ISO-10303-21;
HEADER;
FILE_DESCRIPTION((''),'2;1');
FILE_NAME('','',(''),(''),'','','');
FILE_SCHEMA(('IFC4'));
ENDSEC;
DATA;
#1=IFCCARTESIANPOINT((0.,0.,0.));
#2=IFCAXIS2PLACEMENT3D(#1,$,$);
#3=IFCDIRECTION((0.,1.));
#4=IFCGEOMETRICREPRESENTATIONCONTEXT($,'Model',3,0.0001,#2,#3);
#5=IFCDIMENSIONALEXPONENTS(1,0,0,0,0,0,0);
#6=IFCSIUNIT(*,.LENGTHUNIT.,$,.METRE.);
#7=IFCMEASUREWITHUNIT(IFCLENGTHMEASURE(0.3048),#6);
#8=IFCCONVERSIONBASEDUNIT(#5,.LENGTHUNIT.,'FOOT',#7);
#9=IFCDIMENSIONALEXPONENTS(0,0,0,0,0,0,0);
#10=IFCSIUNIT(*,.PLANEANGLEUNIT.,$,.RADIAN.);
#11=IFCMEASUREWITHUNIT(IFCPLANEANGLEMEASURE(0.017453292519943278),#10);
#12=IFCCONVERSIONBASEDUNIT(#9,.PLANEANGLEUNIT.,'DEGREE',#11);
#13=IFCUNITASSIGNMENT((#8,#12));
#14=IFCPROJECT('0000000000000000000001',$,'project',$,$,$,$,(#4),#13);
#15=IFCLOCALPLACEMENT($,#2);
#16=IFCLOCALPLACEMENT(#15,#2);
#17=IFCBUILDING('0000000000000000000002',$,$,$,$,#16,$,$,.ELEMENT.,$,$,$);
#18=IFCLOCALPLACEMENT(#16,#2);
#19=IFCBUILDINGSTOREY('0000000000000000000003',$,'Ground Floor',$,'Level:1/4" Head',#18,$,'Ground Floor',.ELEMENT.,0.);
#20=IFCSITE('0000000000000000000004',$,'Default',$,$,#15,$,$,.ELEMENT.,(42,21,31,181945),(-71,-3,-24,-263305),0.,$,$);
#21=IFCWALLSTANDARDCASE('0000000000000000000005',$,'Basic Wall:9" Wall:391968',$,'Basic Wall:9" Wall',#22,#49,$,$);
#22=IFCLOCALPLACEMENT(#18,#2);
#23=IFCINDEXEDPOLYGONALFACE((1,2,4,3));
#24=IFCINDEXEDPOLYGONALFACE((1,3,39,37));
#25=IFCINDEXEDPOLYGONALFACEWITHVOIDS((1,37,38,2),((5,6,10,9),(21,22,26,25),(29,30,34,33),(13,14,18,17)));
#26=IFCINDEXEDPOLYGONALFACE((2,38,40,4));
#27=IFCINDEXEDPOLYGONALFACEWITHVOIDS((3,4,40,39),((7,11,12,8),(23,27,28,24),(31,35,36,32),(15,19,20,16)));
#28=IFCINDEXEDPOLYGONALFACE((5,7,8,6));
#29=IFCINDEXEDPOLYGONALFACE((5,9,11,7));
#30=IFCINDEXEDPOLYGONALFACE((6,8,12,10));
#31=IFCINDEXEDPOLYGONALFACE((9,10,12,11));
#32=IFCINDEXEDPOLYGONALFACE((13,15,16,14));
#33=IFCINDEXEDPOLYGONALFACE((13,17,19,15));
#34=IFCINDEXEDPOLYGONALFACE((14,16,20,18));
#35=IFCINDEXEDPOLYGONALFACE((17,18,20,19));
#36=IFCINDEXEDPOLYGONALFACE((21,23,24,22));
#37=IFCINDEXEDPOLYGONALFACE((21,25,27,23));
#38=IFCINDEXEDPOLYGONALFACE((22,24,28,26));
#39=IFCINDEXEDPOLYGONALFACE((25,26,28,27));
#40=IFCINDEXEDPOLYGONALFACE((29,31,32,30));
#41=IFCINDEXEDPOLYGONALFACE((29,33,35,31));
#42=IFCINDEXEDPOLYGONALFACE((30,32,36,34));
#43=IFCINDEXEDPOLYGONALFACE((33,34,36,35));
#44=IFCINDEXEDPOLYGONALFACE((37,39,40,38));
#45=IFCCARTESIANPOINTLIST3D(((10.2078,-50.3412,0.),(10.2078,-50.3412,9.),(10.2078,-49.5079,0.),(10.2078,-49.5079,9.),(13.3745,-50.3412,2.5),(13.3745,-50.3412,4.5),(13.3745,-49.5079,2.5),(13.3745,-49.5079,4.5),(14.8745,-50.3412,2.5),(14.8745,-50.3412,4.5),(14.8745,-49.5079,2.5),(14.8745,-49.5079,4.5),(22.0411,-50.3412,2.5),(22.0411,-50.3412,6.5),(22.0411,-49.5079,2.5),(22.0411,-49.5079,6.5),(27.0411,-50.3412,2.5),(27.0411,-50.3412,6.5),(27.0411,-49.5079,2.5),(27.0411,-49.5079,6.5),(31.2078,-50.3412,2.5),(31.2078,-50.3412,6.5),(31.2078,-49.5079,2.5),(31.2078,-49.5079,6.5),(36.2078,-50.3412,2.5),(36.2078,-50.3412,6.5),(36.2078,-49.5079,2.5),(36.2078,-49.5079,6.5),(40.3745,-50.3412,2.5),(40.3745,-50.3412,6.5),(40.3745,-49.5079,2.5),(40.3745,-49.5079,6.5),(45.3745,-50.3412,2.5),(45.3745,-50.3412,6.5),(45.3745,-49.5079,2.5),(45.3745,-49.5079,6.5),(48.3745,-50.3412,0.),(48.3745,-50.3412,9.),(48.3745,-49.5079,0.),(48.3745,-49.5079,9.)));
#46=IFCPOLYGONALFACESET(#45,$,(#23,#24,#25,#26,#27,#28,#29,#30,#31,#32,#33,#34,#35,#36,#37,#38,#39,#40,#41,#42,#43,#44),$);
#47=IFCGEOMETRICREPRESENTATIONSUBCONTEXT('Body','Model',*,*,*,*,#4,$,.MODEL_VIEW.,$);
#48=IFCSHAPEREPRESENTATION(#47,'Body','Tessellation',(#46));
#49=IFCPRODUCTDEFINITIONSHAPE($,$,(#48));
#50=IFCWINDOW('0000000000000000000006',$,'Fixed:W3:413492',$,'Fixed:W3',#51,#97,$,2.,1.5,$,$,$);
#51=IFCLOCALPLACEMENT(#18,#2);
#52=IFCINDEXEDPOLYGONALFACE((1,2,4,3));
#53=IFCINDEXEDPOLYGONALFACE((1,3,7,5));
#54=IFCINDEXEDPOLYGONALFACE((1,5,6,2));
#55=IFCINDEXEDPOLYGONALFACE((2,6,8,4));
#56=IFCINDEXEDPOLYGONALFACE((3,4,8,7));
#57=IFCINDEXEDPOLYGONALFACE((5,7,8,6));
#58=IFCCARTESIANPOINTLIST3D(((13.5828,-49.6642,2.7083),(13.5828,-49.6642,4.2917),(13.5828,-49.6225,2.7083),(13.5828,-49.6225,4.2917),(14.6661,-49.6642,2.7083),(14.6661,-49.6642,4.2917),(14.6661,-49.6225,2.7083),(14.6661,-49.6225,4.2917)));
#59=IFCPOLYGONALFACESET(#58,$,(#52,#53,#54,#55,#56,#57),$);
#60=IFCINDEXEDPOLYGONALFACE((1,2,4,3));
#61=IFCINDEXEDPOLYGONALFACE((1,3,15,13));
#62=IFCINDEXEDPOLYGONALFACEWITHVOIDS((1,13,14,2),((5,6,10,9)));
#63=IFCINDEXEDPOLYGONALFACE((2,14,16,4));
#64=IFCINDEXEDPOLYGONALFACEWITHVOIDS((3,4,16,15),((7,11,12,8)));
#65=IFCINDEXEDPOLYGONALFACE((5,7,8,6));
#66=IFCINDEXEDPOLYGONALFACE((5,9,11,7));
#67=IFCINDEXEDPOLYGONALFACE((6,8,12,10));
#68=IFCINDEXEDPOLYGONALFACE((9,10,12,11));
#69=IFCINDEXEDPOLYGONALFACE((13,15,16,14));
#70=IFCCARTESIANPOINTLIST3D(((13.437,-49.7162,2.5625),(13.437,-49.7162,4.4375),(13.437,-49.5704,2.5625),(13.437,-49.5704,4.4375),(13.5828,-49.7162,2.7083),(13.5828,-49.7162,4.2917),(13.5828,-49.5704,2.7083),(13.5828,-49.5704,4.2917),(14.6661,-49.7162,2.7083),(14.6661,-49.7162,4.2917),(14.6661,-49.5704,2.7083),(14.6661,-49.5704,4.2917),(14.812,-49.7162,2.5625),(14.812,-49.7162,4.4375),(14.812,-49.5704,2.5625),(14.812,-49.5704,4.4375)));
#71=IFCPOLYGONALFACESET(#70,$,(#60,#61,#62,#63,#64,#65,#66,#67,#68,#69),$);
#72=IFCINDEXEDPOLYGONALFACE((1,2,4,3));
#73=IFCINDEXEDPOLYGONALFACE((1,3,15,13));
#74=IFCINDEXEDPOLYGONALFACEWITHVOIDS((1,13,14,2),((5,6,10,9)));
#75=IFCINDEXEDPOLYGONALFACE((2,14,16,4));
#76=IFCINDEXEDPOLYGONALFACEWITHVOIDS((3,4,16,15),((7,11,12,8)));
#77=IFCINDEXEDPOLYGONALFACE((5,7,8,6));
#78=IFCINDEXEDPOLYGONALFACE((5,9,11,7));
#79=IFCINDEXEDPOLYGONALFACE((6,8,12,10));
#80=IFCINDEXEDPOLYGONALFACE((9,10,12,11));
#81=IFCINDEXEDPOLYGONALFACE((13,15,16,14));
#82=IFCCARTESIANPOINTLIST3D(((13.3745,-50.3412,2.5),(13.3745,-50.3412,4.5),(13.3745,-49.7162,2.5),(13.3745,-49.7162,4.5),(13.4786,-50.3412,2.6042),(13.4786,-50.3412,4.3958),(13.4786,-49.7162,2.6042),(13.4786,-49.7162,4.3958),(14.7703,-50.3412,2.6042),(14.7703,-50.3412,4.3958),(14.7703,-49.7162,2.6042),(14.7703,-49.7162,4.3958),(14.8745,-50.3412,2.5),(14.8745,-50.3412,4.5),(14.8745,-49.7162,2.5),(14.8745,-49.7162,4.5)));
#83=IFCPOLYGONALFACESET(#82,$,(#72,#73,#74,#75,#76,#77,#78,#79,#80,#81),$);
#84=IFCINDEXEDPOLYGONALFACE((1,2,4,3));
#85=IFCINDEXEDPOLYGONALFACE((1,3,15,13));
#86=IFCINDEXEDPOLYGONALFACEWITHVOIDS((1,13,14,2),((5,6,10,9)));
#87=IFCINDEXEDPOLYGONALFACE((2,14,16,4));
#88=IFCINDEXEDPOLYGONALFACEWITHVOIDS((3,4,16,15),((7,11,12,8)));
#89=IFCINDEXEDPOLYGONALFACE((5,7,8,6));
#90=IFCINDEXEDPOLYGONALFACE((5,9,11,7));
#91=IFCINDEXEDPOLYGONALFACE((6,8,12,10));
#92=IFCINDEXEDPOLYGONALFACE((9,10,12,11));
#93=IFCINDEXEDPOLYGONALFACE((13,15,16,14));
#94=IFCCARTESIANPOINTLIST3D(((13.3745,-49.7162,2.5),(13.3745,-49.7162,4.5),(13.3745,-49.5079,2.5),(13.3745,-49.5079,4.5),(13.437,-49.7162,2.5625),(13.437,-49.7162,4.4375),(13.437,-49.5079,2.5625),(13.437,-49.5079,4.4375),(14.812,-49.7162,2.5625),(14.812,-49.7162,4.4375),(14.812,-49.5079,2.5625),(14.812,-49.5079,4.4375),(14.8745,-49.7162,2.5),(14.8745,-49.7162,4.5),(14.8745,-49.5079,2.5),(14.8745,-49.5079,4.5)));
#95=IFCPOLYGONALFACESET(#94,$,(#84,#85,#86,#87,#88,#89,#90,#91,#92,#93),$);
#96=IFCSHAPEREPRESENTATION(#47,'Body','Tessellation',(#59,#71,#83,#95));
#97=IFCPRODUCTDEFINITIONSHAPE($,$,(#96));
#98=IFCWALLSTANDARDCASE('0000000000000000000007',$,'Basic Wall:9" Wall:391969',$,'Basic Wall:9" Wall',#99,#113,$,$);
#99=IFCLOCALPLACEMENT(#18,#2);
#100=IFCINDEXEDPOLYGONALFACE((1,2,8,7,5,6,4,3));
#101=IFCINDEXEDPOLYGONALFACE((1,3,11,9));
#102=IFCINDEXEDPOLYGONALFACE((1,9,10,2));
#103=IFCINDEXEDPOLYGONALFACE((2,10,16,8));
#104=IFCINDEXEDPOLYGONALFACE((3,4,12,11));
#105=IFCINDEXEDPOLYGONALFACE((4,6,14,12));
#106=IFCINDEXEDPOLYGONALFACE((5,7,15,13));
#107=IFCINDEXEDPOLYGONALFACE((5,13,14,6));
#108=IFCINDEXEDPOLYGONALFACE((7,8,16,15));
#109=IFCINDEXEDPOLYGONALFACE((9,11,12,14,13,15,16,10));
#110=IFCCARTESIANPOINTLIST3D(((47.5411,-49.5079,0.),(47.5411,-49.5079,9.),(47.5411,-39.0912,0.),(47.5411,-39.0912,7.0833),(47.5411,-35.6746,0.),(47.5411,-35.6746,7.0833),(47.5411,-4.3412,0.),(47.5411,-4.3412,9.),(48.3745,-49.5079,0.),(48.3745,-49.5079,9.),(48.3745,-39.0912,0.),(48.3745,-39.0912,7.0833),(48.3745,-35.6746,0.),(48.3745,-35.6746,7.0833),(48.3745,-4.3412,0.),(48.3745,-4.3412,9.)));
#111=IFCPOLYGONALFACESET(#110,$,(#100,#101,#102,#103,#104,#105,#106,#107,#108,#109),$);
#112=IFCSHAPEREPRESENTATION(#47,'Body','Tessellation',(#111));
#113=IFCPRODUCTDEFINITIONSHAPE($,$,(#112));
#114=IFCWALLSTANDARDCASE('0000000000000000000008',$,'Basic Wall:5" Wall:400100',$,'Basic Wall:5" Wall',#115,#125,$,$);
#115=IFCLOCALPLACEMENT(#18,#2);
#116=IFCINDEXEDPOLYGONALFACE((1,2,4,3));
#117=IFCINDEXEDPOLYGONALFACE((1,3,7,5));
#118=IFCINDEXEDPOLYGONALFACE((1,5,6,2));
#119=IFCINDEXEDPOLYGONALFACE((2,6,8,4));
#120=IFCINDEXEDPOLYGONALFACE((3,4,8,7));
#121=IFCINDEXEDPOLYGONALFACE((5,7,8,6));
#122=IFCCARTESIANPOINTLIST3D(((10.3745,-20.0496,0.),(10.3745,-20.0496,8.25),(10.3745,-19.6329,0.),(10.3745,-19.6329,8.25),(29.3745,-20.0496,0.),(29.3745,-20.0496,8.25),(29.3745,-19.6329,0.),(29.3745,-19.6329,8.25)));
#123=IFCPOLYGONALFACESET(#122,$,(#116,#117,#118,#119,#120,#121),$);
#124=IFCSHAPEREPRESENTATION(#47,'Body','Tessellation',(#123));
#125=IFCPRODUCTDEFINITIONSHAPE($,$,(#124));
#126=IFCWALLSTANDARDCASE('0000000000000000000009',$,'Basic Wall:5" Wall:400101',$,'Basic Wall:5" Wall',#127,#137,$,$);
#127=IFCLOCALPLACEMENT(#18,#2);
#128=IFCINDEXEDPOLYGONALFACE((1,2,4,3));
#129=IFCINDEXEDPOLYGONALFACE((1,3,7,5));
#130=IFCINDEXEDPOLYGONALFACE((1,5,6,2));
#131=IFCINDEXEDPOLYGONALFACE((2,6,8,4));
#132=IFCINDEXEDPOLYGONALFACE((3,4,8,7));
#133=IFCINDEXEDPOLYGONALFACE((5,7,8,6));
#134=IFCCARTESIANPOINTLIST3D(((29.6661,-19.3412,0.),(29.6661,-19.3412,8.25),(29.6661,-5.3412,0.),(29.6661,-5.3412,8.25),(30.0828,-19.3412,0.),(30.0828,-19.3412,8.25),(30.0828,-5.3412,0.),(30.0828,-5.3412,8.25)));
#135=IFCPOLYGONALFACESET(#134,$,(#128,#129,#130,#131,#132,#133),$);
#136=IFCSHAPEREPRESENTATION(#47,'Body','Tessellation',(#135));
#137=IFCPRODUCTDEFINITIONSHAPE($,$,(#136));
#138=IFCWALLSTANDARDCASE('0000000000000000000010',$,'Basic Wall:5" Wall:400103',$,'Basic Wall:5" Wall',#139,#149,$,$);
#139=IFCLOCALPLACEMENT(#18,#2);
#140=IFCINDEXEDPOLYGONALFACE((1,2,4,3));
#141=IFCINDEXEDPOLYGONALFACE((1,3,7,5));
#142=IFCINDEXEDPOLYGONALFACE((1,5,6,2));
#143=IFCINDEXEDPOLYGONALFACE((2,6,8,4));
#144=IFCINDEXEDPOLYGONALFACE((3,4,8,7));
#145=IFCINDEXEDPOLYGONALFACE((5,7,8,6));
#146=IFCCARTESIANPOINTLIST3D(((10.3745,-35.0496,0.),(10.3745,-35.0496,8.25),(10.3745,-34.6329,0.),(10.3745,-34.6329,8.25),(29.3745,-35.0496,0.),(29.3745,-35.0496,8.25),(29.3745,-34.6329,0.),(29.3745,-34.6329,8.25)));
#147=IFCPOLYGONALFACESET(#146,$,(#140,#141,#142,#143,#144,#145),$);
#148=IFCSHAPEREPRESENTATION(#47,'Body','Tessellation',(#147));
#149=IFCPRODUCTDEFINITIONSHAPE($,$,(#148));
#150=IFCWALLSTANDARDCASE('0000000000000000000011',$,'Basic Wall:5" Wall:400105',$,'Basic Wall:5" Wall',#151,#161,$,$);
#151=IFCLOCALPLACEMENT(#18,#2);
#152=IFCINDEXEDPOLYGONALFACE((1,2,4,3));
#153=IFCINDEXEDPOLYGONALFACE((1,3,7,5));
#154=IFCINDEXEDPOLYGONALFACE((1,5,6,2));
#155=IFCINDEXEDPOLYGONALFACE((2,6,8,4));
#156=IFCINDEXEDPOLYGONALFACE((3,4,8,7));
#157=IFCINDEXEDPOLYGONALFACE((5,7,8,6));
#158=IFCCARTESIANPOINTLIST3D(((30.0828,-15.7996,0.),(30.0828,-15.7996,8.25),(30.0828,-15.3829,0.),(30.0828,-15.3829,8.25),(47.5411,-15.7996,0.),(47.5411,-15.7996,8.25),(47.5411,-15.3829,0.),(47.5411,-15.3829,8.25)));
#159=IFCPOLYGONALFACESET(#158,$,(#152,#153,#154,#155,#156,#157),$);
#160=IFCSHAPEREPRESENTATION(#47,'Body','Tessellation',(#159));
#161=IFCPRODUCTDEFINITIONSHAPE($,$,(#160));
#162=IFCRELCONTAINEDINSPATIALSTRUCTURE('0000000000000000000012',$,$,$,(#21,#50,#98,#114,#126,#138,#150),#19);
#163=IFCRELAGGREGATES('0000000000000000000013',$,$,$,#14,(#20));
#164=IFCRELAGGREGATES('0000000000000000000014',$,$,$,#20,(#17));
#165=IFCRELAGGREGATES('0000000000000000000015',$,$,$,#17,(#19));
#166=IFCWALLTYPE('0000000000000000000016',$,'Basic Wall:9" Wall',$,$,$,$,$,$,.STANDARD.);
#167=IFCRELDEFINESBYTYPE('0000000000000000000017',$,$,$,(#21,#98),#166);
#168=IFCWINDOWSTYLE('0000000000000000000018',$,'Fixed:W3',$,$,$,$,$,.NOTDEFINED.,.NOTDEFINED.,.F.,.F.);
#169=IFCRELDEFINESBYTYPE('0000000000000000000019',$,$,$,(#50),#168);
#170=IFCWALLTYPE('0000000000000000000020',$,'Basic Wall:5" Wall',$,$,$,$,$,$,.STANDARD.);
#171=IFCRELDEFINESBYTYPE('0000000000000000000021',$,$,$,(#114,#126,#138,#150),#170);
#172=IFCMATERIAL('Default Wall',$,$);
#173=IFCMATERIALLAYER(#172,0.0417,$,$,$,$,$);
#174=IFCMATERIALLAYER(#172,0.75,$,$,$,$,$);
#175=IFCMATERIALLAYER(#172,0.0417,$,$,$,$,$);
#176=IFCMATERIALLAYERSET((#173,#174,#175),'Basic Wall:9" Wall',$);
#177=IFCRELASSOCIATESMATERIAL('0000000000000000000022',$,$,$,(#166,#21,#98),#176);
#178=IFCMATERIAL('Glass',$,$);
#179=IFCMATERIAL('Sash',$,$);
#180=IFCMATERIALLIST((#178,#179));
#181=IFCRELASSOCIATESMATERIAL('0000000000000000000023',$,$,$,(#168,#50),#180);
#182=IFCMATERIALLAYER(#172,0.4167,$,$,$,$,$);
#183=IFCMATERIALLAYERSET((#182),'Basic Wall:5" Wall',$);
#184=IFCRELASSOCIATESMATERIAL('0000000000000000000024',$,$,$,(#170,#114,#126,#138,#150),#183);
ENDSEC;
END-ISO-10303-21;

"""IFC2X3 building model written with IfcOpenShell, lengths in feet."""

from ifc_helpers import new_model, entity, si_unit, converted_unit, direction, frame, frame_2d, origin, origin_2d_with_axis, place, context, subcontext, project, spatial, polyline, rectangle, outline, extrude, source, transform, mapped, material, material_list, layer, layer_set, layer_usage, type_object, type_shapes, element, fill, save


model = new_model("IFC2X3")

# Units and contexts
model_context = context("Model", 3, precision=0.0001, world=origin(), true_north=direction((0.0, 1.0)))
body_context = subcontext(model_context, "Body", "Model", "MODEL_VIEW")
ifc_project = project(units=[converted_unit("LENGTHUNIT", "FOOT", entity("IfcLengthMeasure", 0.3048), si_unit("LENGTHUNIT", "METRE"), dimensions=[1, 0, 0, 0, 0, 0, 0]), converted_unit("PLANEANGLEUNIT", "DEGREE", entity("IfcPlaneAngleMeasure", 0.017453292519943278), si_unit("PLANEANGLEUNIT", "RADIAN"), dimensions=[0, 0, 0, 0, 0, 0, 0])], contexts=[model_context])

# Site, building, storey
site_placement = place(None, origin())
site = spatial("IfcSite", under=ifc_project, at=site_placement, Name="Default", CompositionType="ELEMENT", RefLatitude=(42, 21, 31, 181945), RefLongitude=(-71, -3, -24, -263305), RefElevation=0.0)
building_placement = place(site_placement, origin())
building = spatial("IfcBuilding", under=site, at=building_placement, CompositionType="ELEMENT")
storey_placement = place(building_placement, origin())
storey = spatial("IfcBuildingStorey", under=building, at=storey_placement, Name="Ground Floor", ObjectType="Level:1/4\" Head", LongName="Ground Floor", CompositionType="ELEMENT", Elevation=0.0)

# Wall, openings, window
ifc_material_1 = material(Name="Default Wall")
ifc_layer_1 = layer(ifc_material_1, 0.0417)
ifc_layer_2 = layer(ifc_material_1, 0.75)
ifc_layer_3 = layer(ifc_material_1, 0.0417)
ifc_layer_set_1 = layer_set([ifc_layer_1, ifc_layer_2, ifc_layer_3], Name="Basic Wall:9\" Wall")
ifc_layer_usage_1 = layer_usage(ifc_layer_set_1, "AXIS2", "NEGATIVE", 0.4167)
wall_type_1 = type_object("IfcWallType", Name="Basic Wall:9\" Wall", PredefinedType="STANDARD", material=ifc_layer_set_1)
wall_1_placement = place(storey_placement, frame((48.3745, -49.9246, 0.0), z_axis=(0.0, 0.0, 1.0), x_axis=(-1.0, 0.0, 0.0)))
wall_1 = element("IfcWallStandardCase", 1, at=wall_1_placement, inside=storey, type_object=wall_type_1, material=ifc_layer_usage_1, Name="Basic Wall:9\" Wall:391968", ObjectType="Basic Wall:9\" Wall", context=body_context, shape_type="SweptSolid", body=[
    extrude(rectangle(XDim=38.1667, YDim=0.8333, at=frame_2d((19.0833, 0.0), x_axis=(-1.0, 0.0))), origin(), (0.0, 0.0, 1.0), 9.0),
])
opening_1_placement = place(wall_1_placement, frame((3.0, -0.4167, 2.5)))
element("IfcOpeningElement", 2, at=opening_1_placement, cuts=wall_1, ObjectType="Opening", context=body_context, shape_type="SweptSolid", body=[
    extrude(rectangle(XDim=4.0, YDim=5.0, at=frame_2d((2.0, 2.5), x_axis=(-1.0, 0.0))), frame((0.0, 0.0, 0.0), z_axis=(0.0, 1.0, 0.0), x_axis=(0.0, 0.0, 1.0)), (0.0, 0.0, 1.0), 0.8333),
])
opening_2_placement = place(wall_1_placement, frame((12.1667, -0.4167, 2.5)))
element("IfcOpeningElement", 3, at=opening_2_placement, cuts=wall_1, ObjectType="Opening", context=body_context, shape_type="SweptSolid", body=[
    extrude(rectangle(XDim=4.0, YDim=5.0, at=frame_2d((2.0, 2.5), x_axis=(-1.0, 0.0))), frame((0.0, 0.0, 0.0), z_axis=(0.0, 1.0, 0.0), x_axis=(0.0, 0.0, 1.0)), (0.0, 0.0, 1.0), 0.8333),
])
opening_3_placement = place(wall_1_placement, frame((35.0, 0.4167, 2.5)))
opening_3 = element("IfcOpeningElement", 4, at=opening_3_placement, cuts=wall_1, ObjectType="Opening", context=body_context, shape_type="SweptSolid", body=[
    extrude(rectangle(XDim=2.0, YDim=1.5, at=frame_2d((1.0, 0.75), x_axis=(-1.0, 0.0))), frame((0.0, 0.0, 0.0), z_axis=(0.0, -1.0, 0.0), x_axis=(0.0, 0.0, 1.0)), (0.0, 0.0, 1.0), 0.8333),
])
opening_4_placement = place(wall_1_placement, frame((26.3333, 0.4167, 2.5)))
element("IfcOpeningElement", 5, at=opening_4_placement, cuts=wall_1, ObjectType="Opening", context=body_context, shape_type="SweptSolid", body=[
    extrude(rectangle(XDim=4.0, YDim=5.0, at=frame_2d((2.0, 2.5), x_axis=(-1.0, 0.0))), frame((0.0, 0.0, 0.0), z_axis=(0.0, -1.0, 0.0), x_axis=(0.0, 0.0, 1.0)), (0.0, 0.0, 1.0), 0.8333),
])
ifc_material_2 = material(Name="Glass")
ifc_material_3 = material(Name="Sash")
ifc_material_list_1 = material_list([ifc_material_2, ifc_material_3])
window_style = type_object("IfcWindowStyle", Name="Fixed:W3", ConstructionType="NOTDEFINED", OperationType="NOTDEFINED", ParameterTakesPrecedence=False, Sizeable=False, material=ifc_material_list_1)
shared_shape_1 = source(origin(), body_context, "Body", "SweptSolid", [
    extrude(rectangle(XDim=0.0417, YDim=1.0833, at=origin_2d_with_axis()), frame((0.75, 0.6979, 0.2083), z_axis=(0.0, 0.0, 1.0), x_axis=(0.0, 1.0, 0.0)), (0.0, 0.0, 1.0), 1.5833),
    extrude(outline(polyline([(-0.6875, -0.9375), (0.6875, -0.9375), (0.6875, 0.9375), (-0.6875, 0.9375), (-0.6875, -0.9375)]), holes=[polyline([(-0.5417, -0.7917), (-0.5417, 0.7917), (0.5417, 0.7917), (0.5417, -0.7917), (-0.5417, -0.7917)])]), frame((0.75, 0.625, 1.0), z_axis=(0.0, 1.0, 0.0), x_axis=(1.0, 0.0, 0.0)), (0.0, 0.0, 1.0), 0.1458),
    extrude(outline(polyline([(-0.75, -1.0), (0.75, -1.0), (0.75, 1.0), (-0.75, 1.0), (-0.75, -1.0)]), holes=[polyline([(-0.6458, -0.8958), (-0.6458, 0.8958), (0.6458, 0.8958), (0.6458, -0.8958), (-0.6458, -0.8958)])]), frame((0.75, 0.0, 1.0), z_axis=(0.0, 1.0, 0.0), x_axis=(1.0, 0.0, 0.0)), (0.0, 0.0, 1.0), 0.625),
    extrude(outline(polyline([(-1.0, -0.75), (1.0, -0.75), (1.0, 0.75), (-1.0, 0.75), (-1.0, -0.75)]), holes=[polyline([(-0.9375, -0.6875), (-0.9375, 0.6875), (0.9375, 0.6875), (0.9375, -0.6875), (-0.9375, -0.6875)])]), frame((0.75, 0.625, 1.0), z_axis=(0.0, 1.0, 0.0), x_axis=(0.0, 0.0, -1.0)), (0.0, 0.0, 1.0), 0.2083),
])
type_shapes(window_style, [shared_shape_1])
window_placement = place(opening_3_placement, frame((0.0, 0.0, 0.0), z_axis=(0.0, 0.0, 1.0), x_axis=(-1.0, 0.0, 0.0)))
window = element("IfcWindow", 6, at=window_placement, inside=storey, type_object=window_style, material=ifc_material_list_1, Name="Fixed:W3:413492", ObjectType="Fixed:W3", OverallHeight=2.0, OverallWidth=1.5, context=body_context, shape_type="MappedRepresentation", body=[
    mapped(shared_shape_1, transform((0.0, 0.0, 0.0), scale=1.0)),
])
fill(opening_3, window)

# Wall, opening
wall_2_placement = place(storey_placement, frame((47.9578, -4.3412, 0.0), z_axis=(0.0, 0.0, 1.0), x_axis=(0.0, -1.0, 0.0)))
wall_2 = element("IfcWallStandardCase", 7, at=wall_2_placement, inside=storey, type_object=wall_type_1, material=ifc_layer_usage_1, Name="Basic Wall:9\" Wall:391969", ObjectType="Basic Wall:9\" Wall", context=body_context, shape_type="SweptSolid", body=[
    extrude(rectangle(XDim=45.1667, YDim=0.8333, at=frame_2d((22.5833, 0.0), x_axis=(1.0, 0.0))), origin(), (0.0, 0.0, 1.0), 9.0),
])
opening_5_placement = place(wall_2_placement, frame((34.75, 0.4167, 0.0)))
element("IfcOpeningElement", 8, at=opening_5_placement, cuts=wall_2, ObjectType="Opening", context=body_context, shape_type="SweptSolid", body=[
    extrude(rectangle(XDim=7.0833, YDim=3.4167, at=frame_2d((3.5417, 1.7083), x_axis=(1.0, 0.0))), frame((0.0, 0.0, 0.0), z_axis=(0.0, -1.0, 0.0), x_axis=(0.0, 0.0, 1.0)), (0.0, 0.0, 1.0), 0.8333),
])

# Walls
ifc_layer_4 = layer(ifc_material_1, 0.4167)
ifc_layer_set_2 = layer_set([ifc_layer_4], Name="Basic Wall:5\" Wall")
ifc_layer_usage_2 = layer_usage(ifc_layer_set_2, "AXIS2", "NEGATIVE", 0.2083)
wall_type_2 = type_object("IfcWallType", Name="Basic Wall:5\" Wall", PredefinedType="STANDARD", material=ifc_layer_set_2)
wall_3_placement = place(storey_placement, frame((10.3745, -19.8412, 0.0)))
element("IfcWallStandardCase", 9, at=wall_3_placement, inside=storey, type_object=wall_type_2, material=ifc_layer_usage_2, Name="Basic Wall:5\" Wall:400100", ObjectType="Basic Wall:5\" Wall", context=body_context, shape_type="SweptSolid", body=[
    extrude(rectangle(XDim=19.0, YDim=0.4167, at=frame_2d((9.5, 0.0), x_axis=(-1.0, 0.0))), origin(), (0.0, 0.0, 1.0), 8.25),
])
wall_4_placement = place(storey_placement, frame((29.8745, -19.3412, 0.0), z_axis=(0.0, 0.0, 1.0), x_axis=(0.0, 1.0, 0.0)))
element("IfcWallStandardCase", 10, at=wall_4_placement, inside=storey, type_object=wall_type_2, material=ifc_layer_usage_2, Name="Basic Wall:5\" Wall:400101", ObjectType="Basic Wall:5\" Wall", context=body_context, shape_type="SweptSolid", body=[
    extrude(rectangle(XDim=14.0, YDim=0.4167, at=frame_2d((7.0, 0.0), x_axis=(-1.0, 0.0))), origin(), (0.0, 0.0, 1.0), 8.25),
])

# Wall
wall_5_placement = place(storey_placement, frame((29.3745, -34.8412, 0.0), z_axis=(0.0, 0.0, 1.0), x_axis=(-1.0, 0.0, 0.0)))
element("IfcWallStandardCase", 11, at=wall_5_placement, inside=storey, type_object=wall_type_2, material=ifc_layer_usage_2, Name="Basic Wall:5\" Wall:400103", ObjectType="Basic Wall:5\" Wall", context=body_context, shape_type="SweptSolid", body=[
    extrude(rectangle(XDim=19.0, YDim=0.4167, at=frame_2d((9.5, 0.0), x_axis=(-1.0, 0.0))), origin(), (0.0, 0.0, 1.0), 8.25),
])

# Wall
wall_6_placement = place(storey_placement, frame((30.0828, -15.5912, 0.0)))
element("IfcWallStandardCase", 12, at=wall_6_placement, inside=storey, type_object=wall_type_2, material=ifc_layer_usage_2, Name="Basic Wall:5\" Wall:400105", ObjectType="Basic Wall:5\" Wall", context=body_context, shape_type="SweptSolid", body=[
    extrude(rectangle(XDim=17.4583, YDim=0.4167, at=frame_2d((8.7292, 0.0), x_axis=(-1.0, 0.0))), origin(), (0.0, 0.0, 1.0), 8.25),
])

save(model, "model.ifc")
